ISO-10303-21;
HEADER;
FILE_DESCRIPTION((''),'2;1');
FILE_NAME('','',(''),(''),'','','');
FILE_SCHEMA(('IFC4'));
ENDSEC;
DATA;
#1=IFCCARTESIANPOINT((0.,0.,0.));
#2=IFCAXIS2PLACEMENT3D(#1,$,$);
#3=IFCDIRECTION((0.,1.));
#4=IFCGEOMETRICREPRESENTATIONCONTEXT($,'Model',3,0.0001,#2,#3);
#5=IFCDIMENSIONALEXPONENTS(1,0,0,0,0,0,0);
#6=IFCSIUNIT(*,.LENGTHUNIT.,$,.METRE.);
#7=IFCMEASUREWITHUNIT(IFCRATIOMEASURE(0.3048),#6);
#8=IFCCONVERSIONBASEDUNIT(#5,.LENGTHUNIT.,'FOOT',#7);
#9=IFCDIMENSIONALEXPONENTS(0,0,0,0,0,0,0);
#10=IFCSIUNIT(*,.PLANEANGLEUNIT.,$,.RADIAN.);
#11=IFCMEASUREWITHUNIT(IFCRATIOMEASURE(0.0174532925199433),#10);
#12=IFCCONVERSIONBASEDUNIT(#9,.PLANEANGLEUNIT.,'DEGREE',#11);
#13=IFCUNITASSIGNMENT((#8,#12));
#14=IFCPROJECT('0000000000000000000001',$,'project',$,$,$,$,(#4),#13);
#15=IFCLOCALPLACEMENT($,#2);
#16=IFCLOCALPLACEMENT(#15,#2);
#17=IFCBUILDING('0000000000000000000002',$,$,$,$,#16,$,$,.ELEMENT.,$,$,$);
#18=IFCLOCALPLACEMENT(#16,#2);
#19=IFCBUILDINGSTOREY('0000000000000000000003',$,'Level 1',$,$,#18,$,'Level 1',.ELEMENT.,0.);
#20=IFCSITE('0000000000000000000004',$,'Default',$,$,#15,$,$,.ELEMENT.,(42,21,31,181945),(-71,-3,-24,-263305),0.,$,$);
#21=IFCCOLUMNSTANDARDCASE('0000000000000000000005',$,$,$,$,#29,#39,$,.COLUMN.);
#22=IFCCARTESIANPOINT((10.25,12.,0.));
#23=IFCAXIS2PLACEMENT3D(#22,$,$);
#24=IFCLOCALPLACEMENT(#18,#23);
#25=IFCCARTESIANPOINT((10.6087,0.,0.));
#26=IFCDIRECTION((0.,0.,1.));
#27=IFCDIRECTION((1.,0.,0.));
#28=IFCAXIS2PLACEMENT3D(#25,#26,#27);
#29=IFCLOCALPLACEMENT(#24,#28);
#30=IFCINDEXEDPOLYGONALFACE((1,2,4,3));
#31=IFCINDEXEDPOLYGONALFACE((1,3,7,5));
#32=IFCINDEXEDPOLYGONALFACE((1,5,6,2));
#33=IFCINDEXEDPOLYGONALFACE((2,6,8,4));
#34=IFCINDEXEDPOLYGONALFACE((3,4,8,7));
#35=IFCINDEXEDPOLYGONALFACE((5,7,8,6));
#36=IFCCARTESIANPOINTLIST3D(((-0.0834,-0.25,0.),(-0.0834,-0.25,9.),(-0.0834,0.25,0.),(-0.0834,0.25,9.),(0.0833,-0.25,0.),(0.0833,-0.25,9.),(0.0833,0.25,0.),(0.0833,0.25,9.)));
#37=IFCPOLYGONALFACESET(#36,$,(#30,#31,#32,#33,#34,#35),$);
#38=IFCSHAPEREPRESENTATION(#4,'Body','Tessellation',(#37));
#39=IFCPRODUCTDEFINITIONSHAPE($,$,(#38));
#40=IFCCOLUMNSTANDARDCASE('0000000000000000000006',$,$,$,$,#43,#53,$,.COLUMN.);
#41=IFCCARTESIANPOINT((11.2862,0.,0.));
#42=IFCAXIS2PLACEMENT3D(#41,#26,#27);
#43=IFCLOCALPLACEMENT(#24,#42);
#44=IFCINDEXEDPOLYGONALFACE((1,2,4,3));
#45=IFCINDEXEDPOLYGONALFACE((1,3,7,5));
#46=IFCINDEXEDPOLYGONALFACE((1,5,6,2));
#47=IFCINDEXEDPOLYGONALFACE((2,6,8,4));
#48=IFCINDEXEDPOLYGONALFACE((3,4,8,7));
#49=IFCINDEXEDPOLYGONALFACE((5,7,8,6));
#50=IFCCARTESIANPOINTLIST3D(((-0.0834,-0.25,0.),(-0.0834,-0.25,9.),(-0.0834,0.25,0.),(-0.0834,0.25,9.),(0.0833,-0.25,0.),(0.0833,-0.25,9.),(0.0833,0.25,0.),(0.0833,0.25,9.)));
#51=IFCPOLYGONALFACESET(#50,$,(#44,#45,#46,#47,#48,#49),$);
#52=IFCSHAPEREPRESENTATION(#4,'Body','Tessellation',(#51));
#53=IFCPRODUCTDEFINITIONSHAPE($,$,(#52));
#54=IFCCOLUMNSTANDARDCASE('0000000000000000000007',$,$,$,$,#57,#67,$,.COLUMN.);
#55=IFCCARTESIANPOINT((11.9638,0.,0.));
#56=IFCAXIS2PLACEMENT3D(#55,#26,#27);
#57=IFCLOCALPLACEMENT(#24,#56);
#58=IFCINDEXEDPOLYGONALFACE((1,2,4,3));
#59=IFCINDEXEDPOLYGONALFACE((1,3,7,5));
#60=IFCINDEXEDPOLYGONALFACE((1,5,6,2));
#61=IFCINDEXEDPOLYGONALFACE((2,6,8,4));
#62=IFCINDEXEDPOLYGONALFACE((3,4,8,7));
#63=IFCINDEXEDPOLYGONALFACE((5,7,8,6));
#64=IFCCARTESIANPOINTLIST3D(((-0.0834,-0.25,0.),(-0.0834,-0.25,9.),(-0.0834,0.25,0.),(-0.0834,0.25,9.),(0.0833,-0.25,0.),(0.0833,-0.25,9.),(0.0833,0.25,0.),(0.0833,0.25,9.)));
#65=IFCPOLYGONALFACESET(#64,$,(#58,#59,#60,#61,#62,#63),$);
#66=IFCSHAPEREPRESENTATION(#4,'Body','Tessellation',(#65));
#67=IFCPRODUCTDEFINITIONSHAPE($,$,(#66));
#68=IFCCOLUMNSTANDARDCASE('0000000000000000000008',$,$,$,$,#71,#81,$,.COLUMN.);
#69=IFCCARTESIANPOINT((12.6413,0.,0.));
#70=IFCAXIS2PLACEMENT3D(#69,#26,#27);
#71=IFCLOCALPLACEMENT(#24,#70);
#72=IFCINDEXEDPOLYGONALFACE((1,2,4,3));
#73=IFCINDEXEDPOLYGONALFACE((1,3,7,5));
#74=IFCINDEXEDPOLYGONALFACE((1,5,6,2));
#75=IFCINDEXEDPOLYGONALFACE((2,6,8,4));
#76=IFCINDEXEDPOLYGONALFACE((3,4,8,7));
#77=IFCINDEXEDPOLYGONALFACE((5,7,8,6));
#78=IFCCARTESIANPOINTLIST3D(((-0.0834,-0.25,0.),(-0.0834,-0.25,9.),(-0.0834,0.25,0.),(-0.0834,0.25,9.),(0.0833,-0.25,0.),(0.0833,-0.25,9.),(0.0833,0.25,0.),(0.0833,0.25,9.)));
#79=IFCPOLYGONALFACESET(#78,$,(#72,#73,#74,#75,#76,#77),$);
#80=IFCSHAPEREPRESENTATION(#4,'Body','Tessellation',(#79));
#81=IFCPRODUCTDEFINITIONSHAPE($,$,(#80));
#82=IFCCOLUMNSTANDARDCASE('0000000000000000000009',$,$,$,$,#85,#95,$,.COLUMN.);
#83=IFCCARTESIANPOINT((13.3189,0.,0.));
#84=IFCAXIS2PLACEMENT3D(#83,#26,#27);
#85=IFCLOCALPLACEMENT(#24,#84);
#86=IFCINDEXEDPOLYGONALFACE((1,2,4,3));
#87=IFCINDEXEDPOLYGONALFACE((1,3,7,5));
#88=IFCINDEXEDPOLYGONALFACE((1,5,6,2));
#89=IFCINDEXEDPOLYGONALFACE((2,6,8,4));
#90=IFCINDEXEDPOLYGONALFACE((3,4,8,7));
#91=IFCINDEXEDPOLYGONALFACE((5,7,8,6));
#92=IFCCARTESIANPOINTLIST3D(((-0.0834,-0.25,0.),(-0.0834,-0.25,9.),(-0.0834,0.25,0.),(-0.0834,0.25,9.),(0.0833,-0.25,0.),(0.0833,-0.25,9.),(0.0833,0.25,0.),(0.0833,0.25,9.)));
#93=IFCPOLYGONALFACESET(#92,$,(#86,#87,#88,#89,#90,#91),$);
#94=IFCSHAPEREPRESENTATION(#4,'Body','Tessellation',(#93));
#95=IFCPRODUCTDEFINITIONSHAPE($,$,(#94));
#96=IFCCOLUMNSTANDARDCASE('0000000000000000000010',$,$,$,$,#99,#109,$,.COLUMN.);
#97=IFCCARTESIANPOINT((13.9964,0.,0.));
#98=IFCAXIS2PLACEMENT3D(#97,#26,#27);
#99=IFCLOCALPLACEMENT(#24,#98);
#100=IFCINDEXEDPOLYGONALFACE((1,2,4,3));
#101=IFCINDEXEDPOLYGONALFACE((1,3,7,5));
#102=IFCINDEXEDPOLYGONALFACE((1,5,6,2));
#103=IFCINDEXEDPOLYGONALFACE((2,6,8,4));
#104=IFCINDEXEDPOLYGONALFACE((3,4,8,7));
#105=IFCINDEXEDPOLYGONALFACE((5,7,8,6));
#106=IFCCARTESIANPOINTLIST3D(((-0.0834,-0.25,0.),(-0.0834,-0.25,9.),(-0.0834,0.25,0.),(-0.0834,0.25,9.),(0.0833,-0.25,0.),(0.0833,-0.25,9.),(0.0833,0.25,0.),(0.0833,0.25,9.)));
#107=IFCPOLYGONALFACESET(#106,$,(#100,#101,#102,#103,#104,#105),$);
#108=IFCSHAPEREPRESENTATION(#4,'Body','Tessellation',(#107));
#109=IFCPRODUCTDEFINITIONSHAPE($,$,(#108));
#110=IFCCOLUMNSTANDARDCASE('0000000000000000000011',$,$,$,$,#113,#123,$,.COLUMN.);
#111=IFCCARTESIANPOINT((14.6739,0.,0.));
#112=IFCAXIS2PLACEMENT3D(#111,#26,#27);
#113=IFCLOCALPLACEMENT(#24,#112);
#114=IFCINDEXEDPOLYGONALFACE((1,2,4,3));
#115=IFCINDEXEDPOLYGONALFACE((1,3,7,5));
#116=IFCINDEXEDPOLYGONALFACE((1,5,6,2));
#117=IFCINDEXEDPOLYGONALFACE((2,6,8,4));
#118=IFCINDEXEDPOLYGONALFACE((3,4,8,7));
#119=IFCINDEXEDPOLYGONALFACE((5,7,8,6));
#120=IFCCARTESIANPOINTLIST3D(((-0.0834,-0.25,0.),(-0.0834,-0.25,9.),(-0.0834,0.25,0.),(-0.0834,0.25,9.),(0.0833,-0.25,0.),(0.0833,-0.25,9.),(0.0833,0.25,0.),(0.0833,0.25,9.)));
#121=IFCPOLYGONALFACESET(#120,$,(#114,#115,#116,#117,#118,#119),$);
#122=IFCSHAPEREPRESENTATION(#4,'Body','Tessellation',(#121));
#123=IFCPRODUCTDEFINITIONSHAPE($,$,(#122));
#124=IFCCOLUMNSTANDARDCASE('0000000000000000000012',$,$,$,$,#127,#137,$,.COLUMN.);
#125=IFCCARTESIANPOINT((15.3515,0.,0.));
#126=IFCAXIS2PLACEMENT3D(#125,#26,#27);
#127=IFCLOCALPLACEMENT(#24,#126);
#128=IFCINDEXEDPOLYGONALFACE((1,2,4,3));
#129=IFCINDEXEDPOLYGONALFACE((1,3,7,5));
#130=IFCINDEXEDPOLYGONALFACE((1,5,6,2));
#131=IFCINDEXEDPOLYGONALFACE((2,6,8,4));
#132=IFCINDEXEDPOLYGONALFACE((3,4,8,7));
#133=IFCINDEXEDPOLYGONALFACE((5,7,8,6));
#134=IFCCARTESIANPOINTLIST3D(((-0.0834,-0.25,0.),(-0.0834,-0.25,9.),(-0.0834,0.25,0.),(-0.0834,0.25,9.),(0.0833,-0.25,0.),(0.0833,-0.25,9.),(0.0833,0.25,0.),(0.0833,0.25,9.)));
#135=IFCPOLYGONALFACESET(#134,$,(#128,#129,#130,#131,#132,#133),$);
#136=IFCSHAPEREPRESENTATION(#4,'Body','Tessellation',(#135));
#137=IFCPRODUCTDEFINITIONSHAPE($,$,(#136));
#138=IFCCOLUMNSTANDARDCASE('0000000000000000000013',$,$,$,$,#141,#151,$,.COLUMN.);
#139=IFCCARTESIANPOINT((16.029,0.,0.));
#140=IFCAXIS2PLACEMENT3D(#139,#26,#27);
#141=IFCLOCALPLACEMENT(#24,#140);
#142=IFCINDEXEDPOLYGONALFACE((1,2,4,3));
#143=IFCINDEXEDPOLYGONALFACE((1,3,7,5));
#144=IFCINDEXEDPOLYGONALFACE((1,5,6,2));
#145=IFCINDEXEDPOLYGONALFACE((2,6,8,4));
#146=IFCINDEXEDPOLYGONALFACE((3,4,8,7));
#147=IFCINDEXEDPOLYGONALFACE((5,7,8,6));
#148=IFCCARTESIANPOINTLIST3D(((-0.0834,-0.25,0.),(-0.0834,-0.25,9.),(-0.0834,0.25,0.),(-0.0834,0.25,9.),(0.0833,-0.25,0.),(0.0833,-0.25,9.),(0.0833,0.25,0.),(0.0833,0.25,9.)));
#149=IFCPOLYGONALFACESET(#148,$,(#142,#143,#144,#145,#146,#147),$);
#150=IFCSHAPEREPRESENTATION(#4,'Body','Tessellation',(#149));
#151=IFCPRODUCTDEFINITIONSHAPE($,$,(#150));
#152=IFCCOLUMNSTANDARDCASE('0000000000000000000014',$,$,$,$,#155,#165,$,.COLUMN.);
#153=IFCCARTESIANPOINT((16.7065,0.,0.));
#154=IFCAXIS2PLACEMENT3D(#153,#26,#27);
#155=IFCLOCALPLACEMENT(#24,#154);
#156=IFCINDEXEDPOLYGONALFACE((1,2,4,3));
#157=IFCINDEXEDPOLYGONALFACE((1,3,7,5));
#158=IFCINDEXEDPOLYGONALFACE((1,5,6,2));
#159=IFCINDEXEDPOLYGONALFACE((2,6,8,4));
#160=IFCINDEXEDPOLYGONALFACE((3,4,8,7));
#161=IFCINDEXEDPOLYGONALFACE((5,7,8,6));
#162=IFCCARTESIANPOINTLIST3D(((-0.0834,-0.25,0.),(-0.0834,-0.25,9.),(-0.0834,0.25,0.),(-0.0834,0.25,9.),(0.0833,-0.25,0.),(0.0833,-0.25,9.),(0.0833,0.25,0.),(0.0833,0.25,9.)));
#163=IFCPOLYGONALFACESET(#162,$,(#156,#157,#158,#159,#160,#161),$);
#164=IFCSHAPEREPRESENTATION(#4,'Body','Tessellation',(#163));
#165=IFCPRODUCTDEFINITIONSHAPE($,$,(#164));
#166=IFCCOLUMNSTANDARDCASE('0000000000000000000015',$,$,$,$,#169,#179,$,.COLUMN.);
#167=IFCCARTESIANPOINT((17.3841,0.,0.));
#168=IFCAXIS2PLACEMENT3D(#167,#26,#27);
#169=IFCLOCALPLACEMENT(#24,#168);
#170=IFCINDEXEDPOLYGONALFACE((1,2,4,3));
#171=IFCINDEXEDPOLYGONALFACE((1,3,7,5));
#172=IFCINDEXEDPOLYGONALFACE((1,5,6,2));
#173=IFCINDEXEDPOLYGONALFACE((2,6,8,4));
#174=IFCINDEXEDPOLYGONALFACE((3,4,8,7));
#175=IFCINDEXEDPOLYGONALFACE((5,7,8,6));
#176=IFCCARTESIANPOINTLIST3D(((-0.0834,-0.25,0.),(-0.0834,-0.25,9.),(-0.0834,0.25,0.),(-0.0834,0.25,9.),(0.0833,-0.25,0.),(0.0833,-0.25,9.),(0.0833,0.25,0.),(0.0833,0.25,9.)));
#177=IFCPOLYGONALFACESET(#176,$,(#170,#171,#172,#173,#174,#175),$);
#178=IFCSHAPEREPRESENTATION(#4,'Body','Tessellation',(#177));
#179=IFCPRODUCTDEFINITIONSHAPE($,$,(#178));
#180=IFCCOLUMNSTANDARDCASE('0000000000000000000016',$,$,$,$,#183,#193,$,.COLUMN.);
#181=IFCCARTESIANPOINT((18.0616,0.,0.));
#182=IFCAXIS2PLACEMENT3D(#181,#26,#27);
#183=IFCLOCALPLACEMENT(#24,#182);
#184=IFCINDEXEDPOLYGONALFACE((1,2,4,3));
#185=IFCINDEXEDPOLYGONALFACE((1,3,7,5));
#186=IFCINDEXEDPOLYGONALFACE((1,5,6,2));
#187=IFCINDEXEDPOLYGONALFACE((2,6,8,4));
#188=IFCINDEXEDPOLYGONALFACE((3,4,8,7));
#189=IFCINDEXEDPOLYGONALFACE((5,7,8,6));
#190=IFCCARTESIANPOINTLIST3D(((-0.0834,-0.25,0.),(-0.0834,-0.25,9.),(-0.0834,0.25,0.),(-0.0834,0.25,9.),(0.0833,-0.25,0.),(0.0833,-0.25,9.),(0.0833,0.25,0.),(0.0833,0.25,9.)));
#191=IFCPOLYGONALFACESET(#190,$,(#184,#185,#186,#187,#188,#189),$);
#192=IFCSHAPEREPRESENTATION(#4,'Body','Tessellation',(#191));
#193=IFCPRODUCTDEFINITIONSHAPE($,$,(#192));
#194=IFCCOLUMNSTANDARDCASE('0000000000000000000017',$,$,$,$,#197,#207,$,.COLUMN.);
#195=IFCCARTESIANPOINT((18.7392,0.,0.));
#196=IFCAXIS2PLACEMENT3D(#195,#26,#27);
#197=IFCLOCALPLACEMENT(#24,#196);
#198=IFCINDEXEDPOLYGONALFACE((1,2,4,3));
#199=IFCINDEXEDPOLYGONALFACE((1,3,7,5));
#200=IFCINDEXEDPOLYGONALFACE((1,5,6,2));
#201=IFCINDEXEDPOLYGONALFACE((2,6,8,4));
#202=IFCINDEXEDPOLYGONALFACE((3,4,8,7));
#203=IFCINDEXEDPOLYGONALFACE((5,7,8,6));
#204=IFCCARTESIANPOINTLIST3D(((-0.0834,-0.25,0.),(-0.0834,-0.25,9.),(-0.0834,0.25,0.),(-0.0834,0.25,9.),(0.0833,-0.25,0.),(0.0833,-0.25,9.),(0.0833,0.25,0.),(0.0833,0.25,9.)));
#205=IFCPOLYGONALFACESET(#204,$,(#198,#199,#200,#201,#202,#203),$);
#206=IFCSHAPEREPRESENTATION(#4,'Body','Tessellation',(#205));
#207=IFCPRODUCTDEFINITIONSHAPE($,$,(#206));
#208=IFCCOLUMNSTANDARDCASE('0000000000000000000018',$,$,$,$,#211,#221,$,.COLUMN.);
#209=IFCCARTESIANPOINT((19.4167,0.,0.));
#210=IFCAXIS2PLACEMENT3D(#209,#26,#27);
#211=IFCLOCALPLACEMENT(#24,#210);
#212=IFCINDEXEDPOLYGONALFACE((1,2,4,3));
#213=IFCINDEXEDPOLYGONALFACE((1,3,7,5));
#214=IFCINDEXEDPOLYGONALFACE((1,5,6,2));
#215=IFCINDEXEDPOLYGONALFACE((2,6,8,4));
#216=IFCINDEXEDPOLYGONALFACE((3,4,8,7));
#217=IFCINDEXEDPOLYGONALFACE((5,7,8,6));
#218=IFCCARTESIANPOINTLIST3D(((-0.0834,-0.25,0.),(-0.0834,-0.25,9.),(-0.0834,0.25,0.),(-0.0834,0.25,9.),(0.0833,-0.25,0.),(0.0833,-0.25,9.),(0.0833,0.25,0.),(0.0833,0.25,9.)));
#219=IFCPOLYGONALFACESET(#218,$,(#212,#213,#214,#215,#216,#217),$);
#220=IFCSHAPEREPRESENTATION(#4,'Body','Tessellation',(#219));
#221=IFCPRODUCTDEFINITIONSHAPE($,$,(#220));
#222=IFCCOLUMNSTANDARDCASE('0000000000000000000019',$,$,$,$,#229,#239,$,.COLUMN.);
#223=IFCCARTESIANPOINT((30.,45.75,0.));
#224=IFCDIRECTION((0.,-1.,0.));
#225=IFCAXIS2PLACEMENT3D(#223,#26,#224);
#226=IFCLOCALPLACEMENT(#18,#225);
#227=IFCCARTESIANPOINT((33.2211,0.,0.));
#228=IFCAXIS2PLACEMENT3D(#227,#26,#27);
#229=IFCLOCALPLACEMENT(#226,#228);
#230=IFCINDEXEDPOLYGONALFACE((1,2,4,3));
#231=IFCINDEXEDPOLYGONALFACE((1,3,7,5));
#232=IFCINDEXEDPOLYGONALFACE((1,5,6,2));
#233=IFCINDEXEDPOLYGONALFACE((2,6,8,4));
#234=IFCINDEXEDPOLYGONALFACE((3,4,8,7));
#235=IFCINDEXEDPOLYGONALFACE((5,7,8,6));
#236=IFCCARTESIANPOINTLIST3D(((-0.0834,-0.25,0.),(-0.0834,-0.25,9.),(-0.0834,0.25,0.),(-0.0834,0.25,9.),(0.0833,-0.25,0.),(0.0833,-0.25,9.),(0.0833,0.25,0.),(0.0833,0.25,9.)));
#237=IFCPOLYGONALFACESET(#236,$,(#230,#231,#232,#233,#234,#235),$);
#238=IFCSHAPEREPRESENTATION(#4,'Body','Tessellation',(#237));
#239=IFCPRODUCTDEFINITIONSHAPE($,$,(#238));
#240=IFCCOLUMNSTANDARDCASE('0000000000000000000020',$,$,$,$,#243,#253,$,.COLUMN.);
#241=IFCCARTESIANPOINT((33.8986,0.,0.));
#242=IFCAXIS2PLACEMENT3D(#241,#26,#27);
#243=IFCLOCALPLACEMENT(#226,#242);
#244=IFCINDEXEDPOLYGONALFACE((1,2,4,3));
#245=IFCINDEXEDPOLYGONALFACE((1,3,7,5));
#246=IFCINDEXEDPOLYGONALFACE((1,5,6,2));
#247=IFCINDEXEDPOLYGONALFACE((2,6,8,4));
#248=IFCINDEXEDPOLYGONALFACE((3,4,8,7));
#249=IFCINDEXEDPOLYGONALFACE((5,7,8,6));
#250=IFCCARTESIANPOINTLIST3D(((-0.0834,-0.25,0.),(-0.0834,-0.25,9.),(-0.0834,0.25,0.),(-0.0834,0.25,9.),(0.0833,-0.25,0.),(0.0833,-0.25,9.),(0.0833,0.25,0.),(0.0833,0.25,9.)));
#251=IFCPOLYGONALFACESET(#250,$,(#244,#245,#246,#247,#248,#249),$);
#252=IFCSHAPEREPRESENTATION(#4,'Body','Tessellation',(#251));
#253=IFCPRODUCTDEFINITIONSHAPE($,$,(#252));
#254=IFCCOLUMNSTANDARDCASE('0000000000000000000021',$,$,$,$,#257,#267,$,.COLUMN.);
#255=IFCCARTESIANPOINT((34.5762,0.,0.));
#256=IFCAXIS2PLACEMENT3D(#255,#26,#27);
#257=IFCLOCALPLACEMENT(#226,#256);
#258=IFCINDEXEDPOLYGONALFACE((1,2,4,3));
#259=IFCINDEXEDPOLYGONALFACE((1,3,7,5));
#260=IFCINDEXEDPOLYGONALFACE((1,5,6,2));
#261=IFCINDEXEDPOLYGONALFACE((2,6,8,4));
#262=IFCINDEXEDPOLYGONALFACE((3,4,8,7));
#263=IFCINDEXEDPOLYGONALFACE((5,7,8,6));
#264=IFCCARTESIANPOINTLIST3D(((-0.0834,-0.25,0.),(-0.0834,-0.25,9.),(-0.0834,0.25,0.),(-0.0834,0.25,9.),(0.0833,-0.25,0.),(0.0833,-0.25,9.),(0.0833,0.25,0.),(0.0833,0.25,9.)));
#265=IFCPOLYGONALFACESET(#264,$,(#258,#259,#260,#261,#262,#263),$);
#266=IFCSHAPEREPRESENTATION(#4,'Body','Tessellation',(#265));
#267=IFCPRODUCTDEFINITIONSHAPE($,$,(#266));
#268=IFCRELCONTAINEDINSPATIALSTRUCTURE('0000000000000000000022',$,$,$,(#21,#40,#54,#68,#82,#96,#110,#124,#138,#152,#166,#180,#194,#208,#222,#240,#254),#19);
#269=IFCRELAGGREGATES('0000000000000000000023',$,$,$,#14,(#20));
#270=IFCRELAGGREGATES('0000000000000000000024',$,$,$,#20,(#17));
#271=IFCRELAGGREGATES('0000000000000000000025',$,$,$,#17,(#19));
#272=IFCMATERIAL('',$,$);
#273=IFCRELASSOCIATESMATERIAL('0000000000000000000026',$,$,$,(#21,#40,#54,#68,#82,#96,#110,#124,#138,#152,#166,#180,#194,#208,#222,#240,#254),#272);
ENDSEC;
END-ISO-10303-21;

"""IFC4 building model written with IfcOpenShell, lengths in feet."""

from ifc_helpers import new_model, entity, si_unit, converted_unit, direction, frame, origin, place, context, project, spatial, rectangle, extrude, material, element, save


model = new_model("IFC4")

# Units and contexts
model_context = context("Model", 3, precision=0.0001, world=origin(), true_north=direction((0.0, 1.0)))
ifc_project = project(units=[converted_unit("LENGTHUNIT", "FOOT", entity("IfcRatioMeasure", 0.3048), si_unit("LENGTHUNIT", "METRE"), dimensions=[1, 0, 0, 0, 0, 0, 0]), converted_unit("PLANEANGLEUNIT", "DEGREE", entity("IfcRatioMeasure", 0.0174532925199433), si_unit("PLANEANGLEUNIT", "RADIAN"), dimensions=[0, 0, 0, 0, 0, 0, 0])], contexts=[model_context])

# Site, building, storey
site_placement = place(None, origin())
site = spatial("IfcSite", under=ifc_project, at=site_placement, Name="Default", CompositionType="ELEMENT", RefLatitude=(42, 21, 31, 181945), RefLongitude=(-71, -3, -24, -263305), RefElevation=0.0)
building_placement = place(site_placement, origin())
building = spatial("IfcBuilding", under=site, at=building_placement, CompositionType="ELEMENT")
storey_placement = place(building_placement, origin())
storey = spatial("IfcBuildingStorey", under=building, at=storey_placement, Name="Level 1", LongName="Level 1", CompositionType="ELEMENT", Elevation=0.0)

# Columns
ifc_material_1 = material(Name="")
placement_1 = place(storey_placement, frame((10.25, 12.0, 0.0)))
for number, where, z_axis, x_axis in (
    (1, (10.6087, 0.0, 0.0), (0.0, 0.0, 1.0), (1.0, 0.0, 0.0)),
    (2, (11.2862, 0.0, 0.0), (0.0, 0.0, 1.0), (1.0, 0.0, 0.0)),
    (3, (11.9638, 0.0, 0.0), (0.0, 0.0, 1.0), (1.0, 0.0, 0.0)),
    (4, (12.6413, 0.0, 0.0), (0.0, 0.0, 1.0), (1.0, 0.0, 0.0)),
    (5, (13.3189, 0.0, 0.0), (0.0, 0.0, 1.0), (1.0, 0.0, 0.0)),
    (6, (13.9964, 0.0, 0.0), (0.0, 0.0, 1.0), (1.0, 0.0, 0.0)),
    (7, (14.6739, 0.0, 0.0), (0.0, 0.0, 1.0), (1.0, 0.0, 0.0)),
    (8, (15.3515, 0.0, 0.0), (0.0, 0.0, 1.0), (1.0, 0.0, 0.0)),
    (9, (16.029, 0.0, 0.0), (0.0, 0.0, 1.0), (1.0, 0.0, 0.0)),
    (10, (16.7065, 0.0, 0.0), (0.0, 0.0, 1.0), (1.0, 0.0, 0.0)),
    (11, (17.3841, 0.0, 0.0), (0.0, 0.0, 1.0), (1.0, 0.0, 0.0)),
    (12, (18.0616, 0.0, 0.0), (0.0, 0.0, 1.0), (1.0, 0.0, 0.0)),
    (13, (18.7392, 0.0, 0.0), (0.0, 0.0, 1.0), (1.0, 0.0, 0.0)),
    (14, (19.4167, 0.0, 0.0), (0.0, 0.0, 1.0), (1.0, 0.0, 0.0)),
):
    element("IfcColumnStandardCase", number, at=place(placement_1, frame(where, z_axis=z_axis, x_axis=x_axis)), inside=storey, material=ifc_material_1, PredefinedType="COLUMN", context=model_context, shape_type="SweptSolid", body=[
        extrude(rectangle(XDim=0.1667, YDim=0.5), origin(), (0.0, 0.0, 1.0), 9.0),
    ])
placement_2 = place(storey_placement, frame((30.0, 45.75, 0.0), z_axis=(0.0, 0.0, 1.0), x_axis=(0.0, -1.0, 0.0)))
for number, where, z_axis, x_axis in (
    (15, (33.2211, 0.0, 0.0), (0.0, 0.0, 1.0), (1.0, 0.0, 0.0)),
    (16, (33.8986, 0.0, 0.0), (0.0, 0.0, 1.0), (1.0, 0.0, 0.0)),
    (17, (34.5762, 0.0, 0.0), (0.0, 0.0, 1.0), (1.0, 0.0, 0.0)),
):
    element("IfcColumnStandardCase", number, at=place(placement_2, frame(where, z_axis=z_axis, x_axis=x_axis)), inside=storey, material=ifc_material_1, PredefinedType="COLUMN", context=model_context, shape_type="SweptSolid", body=[
        extrude(rectangle(XDim=0.1667, YDim=0.5), origin(), (0.0, 0.0, 1.0), 9.0),
    ])

save(model, "model.ifc")
